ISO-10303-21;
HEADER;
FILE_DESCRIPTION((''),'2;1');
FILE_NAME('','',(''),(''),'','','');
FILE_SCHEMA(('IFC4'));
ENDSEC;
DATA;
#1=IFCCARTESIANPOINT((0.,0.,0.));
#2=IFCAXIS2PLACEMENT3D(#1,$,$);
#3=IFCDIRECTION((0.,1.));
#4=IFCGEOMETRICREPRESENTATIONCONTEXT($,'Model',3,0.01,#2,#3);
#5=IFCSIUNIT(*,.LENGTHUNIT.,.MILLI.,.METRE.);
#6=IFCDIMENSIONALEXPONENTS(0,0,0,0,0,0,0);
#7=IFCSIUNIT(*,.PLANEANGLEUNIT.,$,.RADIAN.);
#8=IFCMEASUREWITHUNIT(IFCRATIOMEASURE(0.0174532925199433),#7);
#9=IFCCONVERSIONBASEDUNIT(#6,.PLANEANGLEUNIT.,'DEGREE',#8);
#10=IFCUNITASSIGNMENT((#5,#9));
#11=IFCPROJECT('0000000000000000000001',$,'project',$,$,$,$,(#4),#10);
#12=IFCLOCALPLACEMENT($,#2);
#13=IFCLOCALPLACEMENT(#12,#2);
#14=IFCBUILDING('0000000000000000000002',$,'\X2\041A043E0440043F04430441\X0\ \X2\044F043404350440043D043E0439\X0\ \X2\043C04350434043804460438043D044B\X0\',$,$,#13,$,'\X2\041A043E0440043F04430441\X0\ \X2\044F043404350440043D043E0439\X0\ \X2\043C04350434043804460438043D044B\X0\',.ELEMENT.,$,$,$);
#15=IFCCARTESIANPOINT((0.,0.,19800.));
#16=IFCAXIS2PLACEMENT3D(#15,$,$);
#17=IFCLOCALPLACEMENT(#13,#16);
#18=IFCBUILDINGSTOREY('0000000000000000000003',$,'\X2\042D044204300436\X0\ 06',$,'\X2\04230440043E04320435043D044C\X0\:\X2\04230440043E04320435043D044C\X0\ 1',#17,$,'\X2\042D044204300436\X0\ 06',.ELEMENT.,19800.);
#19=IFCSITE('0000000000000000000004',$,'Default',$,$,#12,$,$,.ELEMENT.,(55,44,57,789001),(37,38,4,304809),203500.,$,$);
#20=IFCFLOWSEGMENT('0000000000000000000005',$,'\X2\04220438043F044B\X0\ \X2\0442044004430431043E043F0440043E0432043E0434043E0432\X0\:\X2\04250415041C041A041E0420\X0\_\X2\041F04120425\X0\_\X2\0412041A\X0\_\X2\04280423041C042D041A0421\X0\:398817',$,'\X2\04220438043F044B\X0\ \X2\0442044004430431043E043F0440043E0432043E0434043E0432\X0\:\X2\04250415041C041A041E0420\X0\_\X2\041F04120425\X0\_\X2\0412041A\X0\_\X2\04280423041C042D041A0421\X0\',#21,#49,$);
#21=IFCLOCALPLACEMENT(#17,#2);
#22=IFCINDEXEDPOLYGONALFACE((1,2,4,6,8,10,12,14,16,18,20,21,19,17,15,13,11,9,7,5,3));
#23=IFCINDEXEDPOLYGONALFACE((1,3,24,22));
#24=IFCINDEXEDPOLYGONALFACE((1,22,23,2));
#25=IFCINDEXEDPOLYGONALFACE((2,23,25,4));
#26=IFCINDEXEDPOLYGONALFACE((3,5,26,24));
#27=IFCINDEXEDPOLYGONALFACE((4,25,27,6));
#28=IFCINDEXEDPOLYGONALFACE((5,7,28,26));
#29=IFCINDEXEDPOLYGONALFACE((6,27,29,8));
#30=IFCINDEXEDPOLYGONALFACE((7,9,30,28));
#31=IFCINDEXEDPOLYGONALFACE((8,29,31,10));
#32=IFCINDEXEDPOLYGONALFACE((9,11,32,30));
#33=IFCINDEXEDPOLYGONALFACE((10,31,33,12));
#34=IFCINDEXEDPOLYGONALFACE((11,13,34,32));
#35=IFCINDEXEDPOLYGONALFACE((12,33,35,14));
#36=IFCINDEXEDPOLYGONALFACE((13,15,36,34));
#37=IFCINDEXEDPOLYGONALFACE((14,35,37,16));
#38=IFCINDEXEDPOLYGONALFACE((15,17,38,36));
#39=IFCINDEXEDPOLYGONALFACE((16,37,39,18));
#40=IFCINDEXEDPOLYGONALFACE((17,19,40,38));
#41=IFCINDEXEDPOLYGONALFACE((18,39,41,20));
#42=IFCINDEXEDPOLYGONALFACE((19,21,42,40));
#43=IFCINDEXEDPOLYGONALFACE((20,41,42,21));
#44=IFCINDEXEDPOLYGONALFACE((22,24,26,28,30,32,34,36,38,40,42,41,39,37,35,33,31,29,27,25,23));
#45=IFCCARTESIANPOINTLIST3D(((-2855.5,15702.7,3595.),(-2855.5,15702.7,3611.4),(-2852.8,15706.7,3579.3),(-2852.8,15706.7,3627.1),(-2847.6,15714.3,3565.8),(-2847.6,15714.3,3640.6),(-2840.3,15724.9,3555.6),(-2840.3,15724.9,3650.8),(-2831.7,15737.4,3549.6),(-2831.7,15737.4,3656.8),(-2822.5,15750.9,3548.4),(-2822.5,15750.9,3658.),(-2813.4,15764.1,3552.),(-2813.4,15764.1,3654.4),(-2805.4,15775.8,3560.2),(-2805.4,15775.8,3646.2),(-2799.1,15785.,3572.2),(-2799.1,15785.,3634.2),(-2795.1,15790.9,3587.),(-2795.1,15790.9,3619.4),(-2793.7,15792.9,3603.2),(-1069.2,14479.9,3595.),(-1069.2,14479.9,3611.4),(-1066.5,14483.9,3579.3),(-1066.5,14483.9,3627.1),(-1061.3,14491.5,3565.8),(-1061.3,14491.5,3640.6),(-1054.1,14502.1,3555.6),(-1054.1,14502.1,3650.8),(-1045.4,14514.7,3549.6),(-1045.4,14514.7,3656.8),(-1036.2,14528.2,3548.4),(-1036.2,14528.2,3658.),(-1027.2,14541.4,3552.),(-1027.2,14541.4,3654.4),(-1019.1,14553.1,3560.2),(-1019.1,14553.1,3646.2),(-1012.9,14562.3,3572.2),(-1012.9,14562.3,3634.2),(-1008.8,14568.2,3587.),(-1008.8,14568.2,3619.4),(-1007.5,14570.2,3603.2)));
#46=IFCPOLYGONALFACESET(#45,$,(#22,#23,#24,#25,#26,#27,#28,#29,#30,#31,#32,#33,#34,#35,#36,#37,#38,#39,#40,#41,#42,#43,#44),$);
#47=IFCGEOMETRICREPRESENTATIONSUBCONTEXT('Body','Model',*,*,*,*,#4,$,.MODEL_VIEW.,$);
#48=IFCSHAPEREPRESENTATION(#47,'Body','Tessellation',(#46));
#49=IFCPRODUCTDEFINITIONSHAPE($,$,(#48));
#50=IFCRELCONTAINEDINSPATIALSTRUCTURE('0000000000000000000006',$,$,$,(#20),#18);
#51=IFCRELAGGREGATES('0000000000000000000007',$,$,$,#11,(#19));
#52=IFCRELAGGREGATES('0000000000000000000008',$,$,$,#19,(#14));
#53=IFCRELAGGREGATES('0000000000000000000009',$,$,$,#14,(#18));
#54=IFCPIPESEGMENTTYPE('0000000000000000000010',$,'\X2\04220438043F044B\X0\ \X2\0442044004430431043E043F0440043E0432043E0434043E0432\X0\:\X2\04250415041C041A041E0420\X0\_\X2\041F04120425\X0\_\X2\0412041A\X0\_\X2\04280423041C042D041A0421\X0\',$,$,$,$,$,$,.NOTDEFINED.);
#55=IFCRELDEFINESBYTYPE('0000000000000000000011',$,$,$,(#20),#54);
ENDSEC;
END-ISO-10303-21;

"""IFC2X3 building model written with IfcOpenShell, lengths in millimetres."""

from ifc_helpers import new_model, entity, si_unit, converted_unit, direction, frame, origin, origin_2d_with_axis, place, context, subcontext, project, spatial, circle, extrude, type_object, element, save


model = new_model("IFC2X3")

# Units and contexts
model_context = context("Model", 3, precision=0.01, world=origin(), true_north=direction((0.0, 1.0)))
body_context = subcontext(model_context, "Body", "Model", "MODEL_VIEW")
ifc_project = project(units=[si_unit("LENGTHUNIT", "METRE", prefix="MILLI"), converted_unit("PLANEANGLEUNIT", "DEGREE", entity("IfcRatioMeasure", 0.0174532925199433), si_unit("PLANEANGLEUNIT", "RADIAN"), dimensions=[0, 0, 0, 0, 0, 0, 0])], contexts=[model_context])

# Site, building, storey
site_placement = place(None, origin())
site = spatial("IfcSite", under=ifc_project, at=site_placement, Name="Default", CompositionType="ELEMENT", RefLatitude=(55, 44, 57, 789001), RefLongitude=(37, 38, 4, 304809), RefElevation=203500.0)
building_placement = place(site_placement, origin())
building = spatial("IfcBuilding", under=site, at=building_placement, Name="Корпус ядерной медицины", LongName="Корпус ядерной медицины", CompositionType="ELEMENT")
storey_placement = place(building_placement, frame((0.0, 0.0, 19800.0)))
storey = spatial("IfcBuildingStorey", under=building, at=storey_placement, Name="Этаж 06", ObjectType="Уровень:Уровень 1", LongName="Этаж 06", CompositionType="ELEMENT", Elevation=19800.0)

# Flow segment
pipe_segment_type = type_object("IfcPipeSegmentType", Name="Типы трубопроводов:ХЕМКОР_ПВХ_ВК_ШУМЭКС", PredefinedType="NOTDEFINED")
flow_segment_1_placement = place(storey_placement, frame((-2857.5, 14477.8, 3546.6)))
element("IfcFlowSegment", 1, at=flow_segment_1_placement, inside=storey, type_object=pipe_segment_type, Name="Типы трубопроводов:ХЕМКОР_ПВХ_ВК_ШУМЭКС:398817", ObjectType="Типы трубопроводов:ХЕМКОР_ПВХ_ВК_ШУМЭКС", context=body_context, shape_type="SweptSolid", body=[
    extrude(circle(Radius=55.0, at=origin_2d_with_axis()), frame((1818.9, 47.0, 56.6), z_axis=(-0.825187, 0.564859, 0.0), x_axis=(0.564859, 0.825187, 0.0)), (0.0, 0.0, 1.0), 2164.7),
])

save(model, "model.ifc")
